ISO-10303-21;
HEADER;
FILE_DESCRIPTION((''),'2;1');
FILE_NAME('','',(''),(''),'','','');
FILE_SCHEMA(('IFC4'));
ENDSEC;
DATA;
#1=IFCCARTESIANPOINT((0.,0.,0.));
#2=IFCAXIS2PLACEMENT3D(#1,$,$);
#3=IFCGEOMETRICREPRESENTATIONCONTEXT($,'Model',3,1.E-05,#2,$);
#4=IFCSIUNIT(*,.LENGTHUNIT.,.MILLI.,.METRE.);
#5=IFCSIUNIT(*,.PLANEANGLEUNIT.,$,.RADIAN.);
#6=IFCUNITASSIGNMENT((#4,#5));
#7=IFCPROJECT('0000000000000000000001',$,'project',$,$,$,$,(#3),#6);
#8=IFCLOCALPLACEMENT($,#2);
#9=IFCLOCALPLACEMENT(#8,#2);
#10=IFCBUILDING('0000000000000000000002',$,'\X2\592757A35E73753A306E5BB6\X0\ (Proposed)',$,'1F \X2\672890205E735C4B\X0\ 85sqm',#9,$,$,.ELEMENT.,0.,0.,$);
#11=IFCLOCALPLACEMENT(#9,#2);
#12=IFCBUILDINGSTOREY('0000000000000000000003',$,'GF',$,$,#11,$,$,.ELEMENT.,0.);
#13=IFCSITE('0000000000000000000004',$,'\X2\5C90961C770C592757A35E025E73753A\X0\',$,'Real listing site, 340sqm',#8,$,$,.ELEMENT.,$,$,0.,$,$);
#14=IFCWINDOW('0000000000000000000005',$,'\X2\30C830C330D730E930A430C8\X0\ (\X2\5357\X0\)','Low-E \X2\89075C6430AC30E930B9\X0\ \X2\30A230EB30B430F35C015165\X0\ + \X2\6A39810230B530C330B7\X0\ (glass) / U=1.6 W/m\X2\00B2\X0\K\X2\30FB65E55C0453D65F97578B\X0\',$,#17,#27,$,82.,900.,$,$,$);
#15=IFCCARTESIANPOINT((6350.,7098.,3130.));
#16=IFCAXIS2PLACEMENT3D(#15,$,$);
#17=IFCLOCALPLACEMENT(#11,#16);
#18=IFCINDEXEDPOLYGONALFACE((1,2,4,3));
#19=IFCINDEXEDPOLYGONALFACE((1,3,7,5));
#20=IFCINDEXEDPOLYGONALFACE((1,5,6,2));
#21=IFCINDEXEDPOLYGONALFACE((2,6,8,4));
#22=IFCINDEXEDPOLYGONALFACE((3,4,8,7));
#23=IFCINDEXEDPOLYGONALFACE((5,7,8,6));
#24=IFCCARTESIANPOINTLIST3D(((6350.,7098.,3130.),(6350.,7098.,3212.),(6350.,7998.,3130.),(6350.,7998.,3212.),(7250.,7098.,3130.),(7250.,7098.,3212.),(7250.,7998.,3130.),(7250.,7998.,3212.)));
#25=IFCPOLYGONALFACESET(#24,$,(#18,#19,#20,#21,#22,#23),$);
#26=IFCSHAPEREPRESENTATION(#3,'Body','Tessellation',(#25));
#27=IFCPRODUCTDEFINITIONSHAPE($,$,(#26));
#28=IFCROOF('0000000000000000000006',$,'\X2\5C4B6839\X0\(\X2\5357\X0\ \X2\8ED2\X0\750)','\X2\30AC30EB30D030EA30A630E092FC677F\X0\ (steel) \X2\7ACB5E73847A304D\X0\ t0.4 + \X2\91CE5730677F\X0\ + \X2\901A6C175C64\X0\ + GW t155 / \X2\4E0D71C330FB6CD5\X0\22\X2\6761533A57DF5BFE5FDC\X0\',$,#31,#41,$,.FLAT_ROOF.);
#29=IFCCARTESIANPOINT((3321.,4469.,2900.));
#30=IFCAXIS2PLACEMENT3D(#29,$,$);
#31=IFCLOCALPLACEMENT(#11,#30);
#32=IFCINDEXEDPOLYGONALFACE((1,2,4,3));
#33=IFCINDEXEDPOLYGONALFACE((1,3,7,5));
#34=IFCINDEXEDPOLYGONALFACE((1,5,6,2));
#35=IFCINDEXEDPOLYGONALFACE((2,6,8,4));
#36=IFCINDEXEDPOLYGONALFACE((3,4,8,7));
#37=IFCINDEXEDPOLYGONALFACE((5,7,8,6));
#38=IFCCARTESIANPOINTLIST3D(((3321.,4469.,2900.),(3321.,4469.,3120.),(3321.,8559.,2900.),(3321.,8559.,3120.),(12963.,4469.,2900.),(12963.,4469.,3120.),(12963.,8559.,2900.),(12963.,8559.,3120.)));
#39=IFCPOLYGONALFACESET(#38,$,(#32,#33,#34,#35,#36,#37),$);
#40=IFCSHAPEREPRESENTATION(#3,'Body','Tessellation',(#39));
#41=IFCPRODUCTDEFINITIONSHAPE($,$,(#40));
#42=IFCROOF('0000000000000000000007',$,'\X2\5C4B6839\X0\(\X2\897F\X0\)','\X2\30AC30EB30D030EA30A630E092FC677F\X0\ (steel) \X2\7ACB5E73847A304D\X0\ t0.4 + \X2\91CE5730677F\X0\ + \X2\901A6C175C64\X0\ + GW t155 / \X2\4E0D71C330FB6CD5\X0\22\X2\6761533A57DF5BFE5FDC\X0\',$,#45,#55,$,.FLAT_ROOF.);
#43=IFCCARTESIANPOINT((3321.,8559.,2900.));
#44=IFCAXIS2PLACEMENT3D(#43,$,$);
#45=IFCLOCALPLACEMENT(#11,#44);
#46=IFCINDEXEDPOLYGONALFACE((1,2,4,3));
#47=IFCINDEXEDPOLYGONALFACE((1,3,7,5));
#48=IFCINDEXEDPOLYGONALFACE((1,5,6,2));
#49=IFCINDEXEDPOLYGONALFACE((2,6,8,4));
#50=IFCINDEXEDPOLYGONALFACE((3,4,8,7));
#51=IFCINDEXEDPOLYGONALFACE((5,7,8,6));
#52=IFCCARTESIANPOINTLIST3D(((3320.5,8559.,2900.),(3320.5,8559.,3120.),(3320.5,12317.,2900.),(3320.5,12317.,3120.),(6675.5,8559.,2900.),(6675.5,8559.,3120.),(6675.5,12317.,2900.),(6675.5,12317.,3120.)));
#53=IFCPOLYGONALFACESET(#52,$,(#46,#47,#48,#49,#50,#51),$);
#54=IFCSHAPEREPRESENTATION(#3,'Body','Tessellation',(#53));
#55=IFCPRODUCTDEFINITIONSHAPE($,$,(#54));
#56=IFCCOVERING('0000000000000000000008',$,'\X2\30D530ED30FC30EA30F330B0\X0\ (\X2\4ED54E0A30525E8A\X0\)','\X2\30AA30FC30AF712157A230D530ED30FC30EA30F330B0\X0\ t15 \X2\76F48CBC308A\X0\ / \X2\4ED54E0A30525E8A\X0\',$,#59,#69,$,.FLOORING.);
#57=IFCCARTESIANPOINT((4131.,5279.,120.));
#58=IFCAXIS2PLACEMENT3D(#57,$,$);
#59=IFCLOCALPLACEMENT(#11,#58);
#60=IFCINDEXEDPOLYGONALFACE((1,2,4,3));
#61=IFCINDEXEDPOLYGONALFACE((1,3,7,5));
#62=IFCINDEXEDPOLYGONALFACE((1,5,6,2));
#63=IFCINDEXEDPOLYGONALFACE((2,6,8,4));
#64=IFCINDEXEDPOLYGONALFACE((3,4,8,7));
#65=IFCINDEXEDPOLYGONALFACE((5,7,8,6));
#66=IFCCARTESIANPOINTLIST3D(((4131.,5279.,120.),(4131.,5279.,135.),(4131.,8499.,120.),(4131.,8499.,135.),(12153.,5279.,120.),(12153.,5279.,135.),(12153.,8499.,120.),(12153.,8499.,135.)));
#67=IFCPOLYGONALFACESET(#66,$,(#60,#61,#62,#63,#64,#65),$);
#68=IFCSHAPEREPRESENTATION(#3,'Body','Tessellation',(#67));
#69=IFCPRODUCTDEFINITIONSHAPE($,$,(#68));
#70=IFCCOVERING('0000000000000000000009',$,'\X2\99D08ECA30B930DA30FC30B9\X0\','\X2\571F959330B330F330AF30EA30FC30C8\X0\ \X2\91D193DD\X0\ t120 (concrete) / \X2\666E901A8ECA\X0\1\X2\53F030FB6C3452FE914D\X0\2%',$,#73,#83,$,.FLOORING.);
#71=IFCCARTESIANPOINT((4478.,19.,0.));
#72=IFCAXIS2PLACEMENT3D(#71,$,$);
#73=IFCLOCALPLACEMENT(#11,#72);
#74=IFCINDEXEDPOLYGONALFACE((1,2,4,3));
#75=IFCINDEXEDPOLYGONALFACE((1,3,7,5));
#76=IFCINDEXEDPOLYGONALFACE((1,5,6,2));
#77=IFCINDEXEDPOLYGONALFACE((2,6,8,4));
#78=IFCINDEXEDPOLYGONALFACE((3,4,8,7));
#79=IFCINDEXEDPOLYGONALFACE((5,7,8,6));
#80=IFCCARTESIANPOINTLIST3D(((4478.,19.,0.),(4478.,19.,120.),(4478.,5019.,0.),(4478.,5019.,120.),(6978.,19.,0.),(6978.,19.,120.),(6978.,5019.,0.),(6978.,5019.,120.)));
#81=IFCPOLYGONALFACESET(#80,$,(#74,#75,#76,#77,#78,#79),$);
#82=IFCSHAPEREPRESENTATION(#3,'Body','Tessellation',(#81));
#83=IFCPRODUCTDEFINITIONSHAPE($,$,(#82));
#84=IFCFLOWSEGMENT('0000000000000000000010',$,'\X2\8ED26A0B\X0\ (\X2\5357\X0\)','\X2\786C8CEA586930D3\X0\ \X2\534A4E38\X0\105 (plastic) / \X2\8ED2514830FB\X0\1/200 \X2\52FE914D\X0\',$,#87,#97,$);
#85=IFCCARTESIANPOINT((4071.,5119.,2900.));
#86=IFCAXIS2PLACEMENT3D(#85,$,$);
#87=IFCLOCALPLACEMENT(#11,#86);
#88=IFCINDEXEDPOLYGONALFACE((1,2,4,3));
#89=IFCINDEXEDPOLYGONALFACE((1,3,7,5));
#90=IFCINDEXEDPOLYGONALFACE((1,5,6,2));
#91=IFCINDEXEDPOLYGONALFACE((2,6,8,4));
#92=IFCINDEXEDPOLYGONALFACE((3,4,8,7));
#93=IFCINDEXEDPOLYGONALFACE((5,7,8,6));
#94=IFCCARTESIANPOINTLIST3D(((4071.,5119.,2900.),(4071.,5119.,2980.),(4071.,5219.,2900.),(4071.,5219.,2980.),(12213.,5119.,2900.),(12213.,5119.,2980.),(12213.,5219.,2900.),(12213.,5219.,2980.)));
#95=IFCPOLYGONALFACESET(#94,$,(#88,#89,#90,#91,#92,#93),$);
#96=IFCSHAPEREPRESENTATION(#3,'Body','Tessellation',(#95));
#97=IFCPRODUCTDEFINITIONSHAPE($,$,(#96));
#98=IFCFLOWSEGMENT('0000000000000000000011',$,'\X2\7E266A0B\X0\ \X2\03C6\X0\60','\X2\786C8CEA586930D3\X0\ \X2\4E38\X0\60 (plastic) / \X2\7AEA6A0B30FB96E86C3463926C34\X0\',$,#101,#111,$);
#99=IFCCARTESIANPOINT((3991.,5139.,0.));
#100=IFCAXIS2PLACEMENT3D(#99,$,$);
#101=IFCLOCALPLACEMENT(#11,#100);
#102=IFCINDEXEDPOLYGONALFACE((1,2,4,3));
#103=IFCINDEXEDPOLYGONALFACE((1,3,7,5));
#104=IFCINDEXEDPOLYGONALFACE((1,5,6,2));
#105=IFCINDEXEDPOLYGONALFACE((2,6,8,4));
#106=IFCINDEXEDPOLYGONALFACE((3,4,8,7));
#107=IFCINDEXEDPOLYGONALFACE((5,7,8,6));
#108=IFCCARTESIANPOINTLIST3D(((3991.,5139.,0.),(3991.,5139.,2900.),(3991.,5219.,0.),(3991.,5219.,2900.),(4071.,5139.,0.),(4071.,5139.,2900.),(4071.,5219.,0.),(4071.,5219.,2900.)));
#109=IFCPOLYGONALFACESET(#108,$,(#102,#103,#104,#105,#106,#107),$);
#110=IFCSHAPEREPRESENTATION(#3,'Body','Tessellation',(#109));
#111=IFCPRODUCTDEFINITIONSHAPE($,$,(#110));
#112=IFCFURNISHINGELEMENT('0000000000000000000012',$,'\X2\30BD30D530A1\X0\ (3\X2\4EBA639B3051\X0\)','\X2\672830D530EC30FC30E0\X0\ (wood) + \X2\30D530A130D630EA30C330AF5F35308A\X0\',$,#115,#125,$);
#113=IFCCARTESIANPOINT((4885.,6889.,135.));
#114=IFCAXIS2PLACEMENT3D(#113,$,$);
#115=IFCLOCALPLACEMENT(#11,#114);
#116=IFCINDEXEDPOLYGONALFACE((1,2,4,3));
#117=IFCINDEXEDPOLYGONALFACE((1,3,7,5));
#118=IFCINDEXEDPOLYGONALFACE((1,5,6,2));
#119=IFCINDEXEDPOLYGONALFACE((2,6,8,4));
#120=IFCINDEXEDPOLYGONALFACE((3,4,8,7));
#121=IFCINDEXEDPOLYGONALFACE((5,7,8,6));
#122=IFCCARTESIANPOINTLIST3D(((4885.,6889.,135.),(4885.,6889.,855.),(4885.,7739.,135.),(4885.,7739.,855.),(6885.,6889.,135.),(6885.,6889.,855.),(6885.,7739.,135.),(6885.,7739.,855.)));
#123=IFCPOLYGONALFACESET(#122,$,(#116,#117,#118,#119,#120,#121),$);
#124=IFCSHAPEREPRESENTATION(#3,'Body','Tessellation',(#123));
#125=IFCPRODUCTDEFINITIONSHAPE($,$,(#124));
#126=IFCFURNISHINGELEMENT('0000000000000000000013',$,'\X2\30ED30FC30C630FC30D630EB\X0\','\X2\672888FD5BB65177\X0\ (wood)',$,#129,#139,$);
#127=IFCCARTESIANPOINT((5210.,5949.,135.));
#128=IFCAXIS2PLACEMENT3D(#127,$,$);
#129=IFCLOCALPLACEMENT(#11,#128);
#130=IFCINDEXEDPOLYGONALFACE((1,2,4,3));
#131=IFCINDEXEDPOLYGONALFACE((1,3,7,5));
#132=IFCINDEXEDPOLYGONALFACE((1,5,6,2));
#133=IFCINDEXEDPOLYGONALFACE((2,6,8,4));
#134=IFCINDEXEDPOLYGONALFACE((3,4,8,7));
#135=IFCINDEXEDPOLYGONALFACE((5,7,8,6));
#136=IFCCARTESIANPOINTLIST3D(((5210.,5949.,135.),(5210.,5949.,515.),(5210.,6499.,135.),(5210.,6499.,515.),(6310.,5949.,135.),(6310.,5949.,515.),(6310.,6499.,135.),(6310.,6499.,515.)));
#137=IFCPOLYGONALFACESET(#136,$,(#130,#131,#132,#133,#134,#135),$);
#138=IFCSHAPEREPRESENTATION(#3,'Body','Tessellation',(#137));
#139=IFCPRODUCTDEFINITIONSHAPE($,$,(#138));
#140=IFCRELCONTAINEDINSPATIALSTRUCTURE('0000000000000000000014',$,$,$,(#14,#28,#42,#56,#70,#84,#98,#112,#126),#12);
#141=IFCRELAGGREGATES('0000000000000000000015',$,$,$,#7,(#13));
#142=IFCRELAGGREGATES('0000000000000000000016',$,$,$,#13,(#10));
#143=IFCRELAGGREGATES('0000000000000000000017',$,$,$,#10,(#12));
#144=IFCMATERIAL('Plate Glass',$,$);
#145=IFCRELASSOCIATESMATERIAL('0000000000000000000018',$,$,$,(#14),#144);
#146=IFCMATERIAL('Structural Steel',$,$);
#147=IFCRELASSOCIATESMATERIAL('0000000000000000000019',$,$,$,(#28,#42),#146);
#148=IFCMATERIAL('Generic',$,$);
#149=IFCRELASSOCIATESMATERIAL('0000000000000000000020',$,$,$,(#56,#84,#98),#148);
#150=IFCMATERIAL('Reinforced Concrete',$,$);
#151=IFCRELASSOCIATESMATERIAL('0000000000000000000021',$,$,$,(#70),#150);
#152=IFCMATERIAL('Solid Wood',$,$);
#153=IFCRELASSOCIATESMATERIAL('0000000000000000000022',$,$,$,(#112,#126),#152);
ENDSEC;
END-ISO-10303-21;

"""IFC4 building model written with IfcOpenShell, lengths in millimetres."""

from ifc_helpers import new_model, si_unit, frame, frame_2d, origin, place, context, project, spatial, rectangle, extrude, material, element, save


model = new_model("IFC4")

# Units and contexts
model_context = context("Model", 3, precision=1e-05, world=origin())
ifc_project = project(units=[si_unit("LENGTHUNIT", "METRE", prefix="MILLI"), si_unit("PLANEANGLEUNIT", "RADIAN")], contexts=[model_context])

# Site, building, storey
site_placement = place(None, origin())
site = spatial("IfcSite", under=ifc_project, at=site_placement, Name="岐阜県大垣市平町", ObjectType="Real listing site, 340sqm", CompositionType="ELEMENT", RefElevation=0.0)
building_placement = place(site_placement, origin())
building = spatial("IfcBuilding", under=site, at=building_placement, Name="大垣平町の家 (Proposed)", ObjectType="1F 木造平屋 85sqm", CompositionType="ELEMENT", ElevationOfRefHeight=0.0, ElevationOfTerrain=0.0)
storey_placement = place(building_placement, origin())
storey = spatial("IfcBuildingStorey", under=building, at=storey_placement, Name="GF", CompositionType="ELEMENT", Elevation=0.0)

# Shared definitions
ifc_material_1 = material(Name="Solid Wood")

# Shared definitions
ifc_material_2 = material(Name="Reinforced Concrete")

# Shared definitions
ifc_material_3 = material(Name="Plate Glass")

# Window
window_1_placement = place(storey_placement, frame((6350.0, 7098.0, 3130.0)))
element("IfcWindow", 1, at=window_1_placement, inside=storey, material=ifc_material_3, Name="トップライト (南)", Description="Low-E 複層ガラス アルゴン封入 + 樹脂サッシ (glass) / U=1.6 W/m²K・日射取得型", OverallHeight=82.0, OverallWidth=900.0, context=model_context, shape_type="SweptSolid", body=[
    extrude(rectangle(XDim=900.0, YDim=900.0, at=frame_2d((450.0, 450.0))), frame((6350.0, 7098.0, 3130.0)), (0.0, 0.0, 1.0), 82.0),
])

# Roofs
ifc_material_4 = material(Name="Structural Steel")
roof_1_placement = place(storey_placement, frame((3321.0, 4469.0, 2900.0)))
element("IfcRoof", 2, at=roof_1_placement, inside=storey, material=ifc_material_4, Name="屋根(南 軒750)", Description="ガルバリウム鋼板 (steel) 立平葺き t0.4 + 野地板 + 通気層 + GW t155 / 不燃・法22条区域対応", PredefinedType="FLAT_ROOF", context=model_context, shape_type="SweptSolid", body=[
    extrude(rectangle(XDim=9642.0, YDim=4090.0, at=frame_2d((4821.0, 2045.0))), frame((3321.0, 4469.0, 2900.0)), (0.0, 0.0, 1.0), 220.0),
])
roof_2_placement = place(storey_placement, frame((3321.0, 8559.0, 2900.0)))
element("IfcRoof", 3, at=roof_2_placement, inside=storey, material=ifc_material_4, Name="屋根(西)", Description="ガルバリウム鋼板 (steel) 立平葺き t0.4 + 野地板 + 通気層 + GW t155 / 不燃・法22条区域対応", PredefinedType="FLAT_ROOF", context=model_context, shape_type="SweptSolid", body=[
    extrude(rectangle(XDim=3355.0, YDim=3758.0, at=frame_2d((1677.0, 1879.0))), frame((3321.0, 8559.0, 2900.0)), (0.0, 0.0, 1.0), 220.0),
])

# Coverings
ifc_material_5 = material(Name="Generic")
covering_1_placement = place(storey_placement, frame((4131.0, 5279.0, 120.0)))
element("IfcCovering", 4, at=covering_1_placement, inside=storey, material=ifc_material_5, Name="フローリング (仕上げ床)", Description="オーク無垢フローリング t15 直貼り / 仕上げ床", PredefinedType="FLOORING", context=model_context, shape_type="SweptSolid", body=[
    extrude(rectangle(XDim=8022.0, YDim=3220.0, at=frame_2d((4011.0, 1610.0))), frame((4131.0, 5279.0, 120.0)), (0.0, 0.0, 1.0), 15.0),
])
covering_2_placement = place(storey_placement, frame((4478.0, 19.0, 0.0)))
element("IfcCovering", 5, at=covering_2_placement, inside=storey, material=ifc_material_2, Name="駐車スペース", Description="土間コンクリート 金鏝 t120 (concrete) / 普通車1台・水勾配2%", PredefinedType="FLOORING", context=model_context, shape_type="SweptSolid", body=[
    extrude(rectangle(XDim=2500.0, YDim=5000.0, at=frame_2d((1250.0, 2500.0))), frame((4478.0, 19.0, 0.0)), (0.0, 0.0, 1.0), 120.0),
])

# Flow segments
flow_segment_1_placement = place(storey_placement, frame((4071.0, 5119.0, 2900.0)))
element("IfcFlowSegment", 6, at=flow_segment_1_placement, inside=storey, material=ifc_material_5, Name="軒樋 (南)", Description="硬質塩ビ 半丸105 (plastic) / 軒先・1/200 勾配", context=model_context, shape_type="SweptSolid", body=[
    extrude(rectangle(XDim=8142.0, YDim=100.0, at=frame_2d((4071.0, 50.0))), frame((4071.0, 5119.0, 2900.0)), (0.0, 0.0, 1.0), 80.0),
])
flow_segment_2_placement = place(storey_placement, frame((3991.0, 5139.0, 0.0)))
element("IfcFlowSegment", 7, at=flow_segment_2_placement, inside=storey, material=ifc_material_5, Name="縦樋 φ60", Description="硬質塩ビ 丸60 (plastic) / 竪樋・雨水排水", context=model_context, shape_type="SweptSolid", body=[
    extrude(rectangle(XDim=80.0, YDim=80.0, at=frame_2d((40.0, 40.0))), frame((3991.0, 5139.0, 0.0)), (0.0, 0.0, 1.0), 2900.0),
])

# Furnishing elements
furnishing_1_placement = place(storey_placement, frame((4885.0, 6889.0, 135.0)))
element("IfcFurnishingElement", 8, at=furnishing_1_placement, inside=storey, material=ifc_material_1, Name="ソファ (3人掛け)", Description="木フレーム (wood) + ファブリック張り", context=model_context, shape_type="SweptSolid", body=[
    extrude(rectangle(XDim=2000.0, YDim=850.0, at=frame_2d((1000.0, 425.0))), frame((4885.0, 6889.0, 135.0)), (0.0, 0.0, 1.0), 720.0),
])
furnishing_2_placement = place(storey_placement, frame((5210.0, 5949.0, 135.0)))
element("IfcFurnishingElement", 9, at=furnishing_2_placement, inside=storey, material=ifc_material_1, Name="ローテーブル", Description="木製家具 (wood)", context=model_context, shape_type="SweptSolid", body=[
    extrude(rectangle(XDim=1100.0, YDim=550.0, at=frame_2d((550.0, 275.0))), frame((5210.0, 5949.0, 135.0)), (0.0, 0.0, 1.0), 380.0),
])

save(model, "model.ifc")
